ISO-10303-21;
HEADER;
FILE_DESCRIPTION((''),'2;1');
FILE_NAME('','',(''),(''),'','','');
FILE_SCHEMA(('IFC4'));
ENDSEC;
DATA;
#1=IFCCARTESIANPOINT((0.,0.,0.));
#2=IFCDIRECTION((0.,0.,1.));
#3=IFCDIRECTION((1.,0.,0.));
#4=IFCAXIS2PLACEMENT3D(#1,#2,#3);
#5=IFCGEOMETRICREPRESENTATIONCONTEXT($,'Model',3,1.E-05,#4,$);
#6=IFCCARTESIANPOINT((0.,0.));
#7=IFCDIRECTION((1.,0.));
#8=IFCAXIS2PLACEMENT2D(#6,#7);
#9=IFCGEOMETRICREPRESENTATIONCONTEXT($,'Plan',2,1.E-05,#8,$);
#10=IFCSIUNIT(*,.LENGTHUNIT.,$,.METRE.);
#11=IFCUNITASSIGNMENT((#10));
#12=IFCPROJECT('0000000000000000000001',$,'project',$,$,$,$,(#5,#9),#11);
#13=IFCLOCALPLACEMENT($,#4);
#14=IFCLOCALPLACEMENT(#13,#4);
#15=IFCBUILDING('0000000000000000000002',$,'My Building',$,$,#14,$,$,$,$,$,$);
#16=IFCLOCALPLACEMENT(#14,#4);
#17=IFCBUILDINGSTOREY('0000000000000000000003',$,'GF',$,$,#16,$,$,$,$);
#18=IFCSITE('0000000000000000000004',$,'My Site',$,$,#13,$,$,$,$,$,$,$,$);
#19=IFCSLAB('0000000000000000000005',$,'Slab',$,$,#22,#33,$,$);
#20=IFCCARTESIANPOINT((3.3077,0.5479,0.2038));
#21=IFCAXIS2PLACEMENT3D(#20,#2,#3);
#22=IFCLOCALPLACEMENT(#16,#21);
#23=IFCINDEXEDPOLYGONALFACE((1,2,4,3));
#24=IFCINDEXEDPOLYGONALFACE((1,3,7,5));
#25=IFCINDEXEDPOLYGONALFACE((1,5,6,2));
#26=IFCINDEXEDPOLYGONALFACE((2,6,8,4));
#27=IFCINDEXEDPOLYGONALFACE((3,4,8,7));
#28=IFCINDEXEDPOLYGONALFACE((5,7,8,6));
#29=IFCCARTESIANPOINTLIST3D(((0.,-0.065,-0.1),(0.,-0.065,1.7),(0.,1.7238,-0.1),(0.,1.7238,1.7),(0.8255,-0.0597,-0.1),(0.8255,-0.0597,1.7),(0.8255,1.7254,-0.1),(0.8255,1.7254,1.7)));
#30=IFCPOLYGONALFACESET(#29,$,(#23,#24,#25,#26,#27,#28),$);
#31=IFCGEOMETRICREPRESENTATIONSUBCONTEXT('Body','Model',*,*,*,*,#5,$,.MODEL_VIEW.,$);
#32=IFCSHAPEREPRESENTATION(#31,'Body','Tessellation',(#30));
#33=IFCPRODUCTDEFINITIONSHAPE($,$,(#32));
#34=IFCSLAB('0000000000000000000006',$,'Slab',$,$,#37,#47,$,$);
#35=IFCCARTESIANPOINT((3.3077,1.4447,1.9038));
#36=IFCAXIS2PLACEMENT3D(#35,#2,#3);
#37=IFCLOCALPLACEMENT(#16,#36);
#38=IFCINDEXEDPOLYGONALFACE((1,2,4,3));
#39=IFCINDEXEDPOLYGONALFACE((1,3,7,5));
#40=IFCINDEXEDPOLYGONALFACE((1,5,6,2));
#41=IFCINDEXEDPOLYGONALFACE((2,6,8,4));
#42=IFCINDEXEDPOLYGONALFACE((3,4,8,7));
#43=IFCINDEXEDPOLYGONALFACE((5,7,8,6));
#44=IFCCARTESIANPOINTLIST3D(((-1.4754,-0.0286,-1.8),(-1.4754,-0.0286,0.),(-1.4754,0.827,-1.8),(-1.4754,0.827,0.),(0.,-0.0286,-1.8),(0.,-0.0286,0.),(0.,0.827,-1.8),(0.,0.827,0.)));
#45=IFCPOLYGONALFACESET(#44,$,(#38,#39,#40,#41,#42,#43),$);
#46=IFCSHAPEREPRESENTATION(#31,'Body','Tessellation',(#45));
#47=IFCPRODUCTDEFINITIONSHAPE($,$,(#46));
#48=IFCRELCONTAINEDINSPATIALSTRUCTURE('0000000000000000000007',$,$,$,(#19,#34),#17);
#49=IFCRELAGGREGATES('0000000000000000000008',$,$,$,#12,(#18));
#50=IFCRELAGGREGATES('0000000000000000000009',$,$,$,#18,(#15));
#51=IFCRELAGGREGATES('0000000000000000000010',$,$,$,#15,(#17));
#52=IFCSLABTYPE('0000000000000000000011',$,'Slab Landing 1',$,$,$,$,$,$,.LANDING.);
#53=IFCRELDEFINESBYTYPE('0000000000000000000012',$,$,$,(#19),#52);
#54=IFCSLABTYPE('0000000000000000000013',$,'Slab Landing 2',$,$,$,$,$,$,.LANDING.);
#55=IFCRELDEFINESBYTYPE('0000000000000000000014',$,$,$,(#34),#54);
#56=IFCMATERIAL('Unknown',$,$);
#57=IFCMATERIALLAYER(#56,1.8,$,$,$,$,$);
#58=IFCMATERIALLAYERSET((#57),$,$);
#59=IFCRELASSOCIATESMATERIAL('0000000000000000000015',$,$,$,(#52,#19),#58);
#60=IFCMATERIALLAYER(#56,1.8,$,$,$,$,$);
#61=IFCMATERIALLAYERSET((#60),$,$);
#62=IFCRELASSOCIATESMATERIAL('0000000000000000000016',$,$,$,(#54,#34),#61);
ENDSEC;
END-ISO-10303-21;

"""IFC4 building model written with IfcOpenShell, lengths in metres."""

from ifc_helpers import new_model, si_unit, frame, origin_with_axes, origin_2d_with_axis, place, context, subcontext, project, spatial, indexed_curve, outline, extrude, material, layer, layer_set, layer_usage, type_object, element, save


model = new_model("IFC4")

# Units and contexts
model_context = context("Model", 3, precision=1e-05, world=origin_with_axes())
plan_context = context("Plan", 2, precision=1e-05, world=origin_2d_with_axis())
body_context_1 = subcontext(model_context, "Body", "Model", "MODEL_VIEW")
ifc_project = project(units=[si_unit("LENGTHUNIT", "METRE")], contexts=[model_context, plan_context])

# Site, building, storey
site_placement = place(None, origin_with_axes())
site = spatial("IfcSite", under=ifc_project, at=site_placement, Name="My Site")
building_placement = place(site_placement, origin_with_axes())
building = spatial("IfcBuilding", under=site, at=building_placement, Name="My Building")
storey_placement = place(building_placement, origin_with_axes())
storey = spatial("IfcBuildingStorey", under=building, at=storey_placement, Name="GF")

# Shared definitions
ifc_material = material(Name="Unknown")

# Slabs
ifc_layer_1 = layer(ifc_material, 1.8)
ifc_layer_set_1 = layer_set([ifc_layer_1])
ifc_layer_usage_1 = layer_usage(ifc_layer_set_1, "AXIS3", "POSITIVE", -0.1)
slab_type_1 = type_object("IfcSlabType", Name="Slab Landing 1", PredefinedType="LANDING", material=ifc_layer_set_1)
slab_1_placement = place(storey_placement, frame((3.3077, 0.5479, 0.2038), z_axis=(0.0, 0.0, 1.0), x_axis=(1.0, 0.0, 0.0)))
element("IfcSlab", 1, at=slab_1_placement, inside=storey, type_object=slab_type_1, material=ifc_layer_usage_1, Name="Slab", context=body_context_1, shape_type="SweptSolid", body=[
    extrude(outline(indexed_curve([(0.8255, -0.0597), (0.8255, 1.7254), (0.0, 1.7238), (0.0, -0.065), (0.8255, -0.0597)])), frame((0.0, 0.0, -0.1), z_axis=(0.0, 0.0, 1.0), x_axis=(1.0, 0.0, 0.0)), (0.0, 0.0, 1.0), 1.8),
])
ifc_layer_2 = layer(ifc_material, 1.8)
ifc_layer_set_2 = layer_set([ifc_layer_2])
ifc_layer_usage_2 = layer_usage(ifc_layer_set_2, "AXIS3", "POSITIVE", -1.8)
slab_type_2 = type_object("IfcSlabType", Name="Slab Landing 2", PredefinedType="LANDING", material=ifc_layer_set_2)
slab_2_placement = place(storey_placement, frame((3.3077, 1.4447, 1.9038), z_axis=(0.0, 0.0, 1.0), x_axis=(1.0, 0.0, 0.0)))
element("IfcSlab", 2, at=slab_2_placement, inside=storey, type_object=slab_type_2, material=ifc_layer_usage_2, Name="Slab", context=body_context_1, shape_type="SweptSolid", body=[
    extrude(outline(indexed_curve([(-1.4754, -0.0286), (-1.4754, 0.827), (0.0, 0.827), (0.0, -0.0286), (-1.4754, -0.0286)])), frame((0.0, 0.0, -1.8), z_axis=(0.0, 0.0, 1.0), x_axis=(1.0, 0.0, 0.0)), (0.0, 0.0, 1.0), 1.8),
])

save(model, "model.ifc")
